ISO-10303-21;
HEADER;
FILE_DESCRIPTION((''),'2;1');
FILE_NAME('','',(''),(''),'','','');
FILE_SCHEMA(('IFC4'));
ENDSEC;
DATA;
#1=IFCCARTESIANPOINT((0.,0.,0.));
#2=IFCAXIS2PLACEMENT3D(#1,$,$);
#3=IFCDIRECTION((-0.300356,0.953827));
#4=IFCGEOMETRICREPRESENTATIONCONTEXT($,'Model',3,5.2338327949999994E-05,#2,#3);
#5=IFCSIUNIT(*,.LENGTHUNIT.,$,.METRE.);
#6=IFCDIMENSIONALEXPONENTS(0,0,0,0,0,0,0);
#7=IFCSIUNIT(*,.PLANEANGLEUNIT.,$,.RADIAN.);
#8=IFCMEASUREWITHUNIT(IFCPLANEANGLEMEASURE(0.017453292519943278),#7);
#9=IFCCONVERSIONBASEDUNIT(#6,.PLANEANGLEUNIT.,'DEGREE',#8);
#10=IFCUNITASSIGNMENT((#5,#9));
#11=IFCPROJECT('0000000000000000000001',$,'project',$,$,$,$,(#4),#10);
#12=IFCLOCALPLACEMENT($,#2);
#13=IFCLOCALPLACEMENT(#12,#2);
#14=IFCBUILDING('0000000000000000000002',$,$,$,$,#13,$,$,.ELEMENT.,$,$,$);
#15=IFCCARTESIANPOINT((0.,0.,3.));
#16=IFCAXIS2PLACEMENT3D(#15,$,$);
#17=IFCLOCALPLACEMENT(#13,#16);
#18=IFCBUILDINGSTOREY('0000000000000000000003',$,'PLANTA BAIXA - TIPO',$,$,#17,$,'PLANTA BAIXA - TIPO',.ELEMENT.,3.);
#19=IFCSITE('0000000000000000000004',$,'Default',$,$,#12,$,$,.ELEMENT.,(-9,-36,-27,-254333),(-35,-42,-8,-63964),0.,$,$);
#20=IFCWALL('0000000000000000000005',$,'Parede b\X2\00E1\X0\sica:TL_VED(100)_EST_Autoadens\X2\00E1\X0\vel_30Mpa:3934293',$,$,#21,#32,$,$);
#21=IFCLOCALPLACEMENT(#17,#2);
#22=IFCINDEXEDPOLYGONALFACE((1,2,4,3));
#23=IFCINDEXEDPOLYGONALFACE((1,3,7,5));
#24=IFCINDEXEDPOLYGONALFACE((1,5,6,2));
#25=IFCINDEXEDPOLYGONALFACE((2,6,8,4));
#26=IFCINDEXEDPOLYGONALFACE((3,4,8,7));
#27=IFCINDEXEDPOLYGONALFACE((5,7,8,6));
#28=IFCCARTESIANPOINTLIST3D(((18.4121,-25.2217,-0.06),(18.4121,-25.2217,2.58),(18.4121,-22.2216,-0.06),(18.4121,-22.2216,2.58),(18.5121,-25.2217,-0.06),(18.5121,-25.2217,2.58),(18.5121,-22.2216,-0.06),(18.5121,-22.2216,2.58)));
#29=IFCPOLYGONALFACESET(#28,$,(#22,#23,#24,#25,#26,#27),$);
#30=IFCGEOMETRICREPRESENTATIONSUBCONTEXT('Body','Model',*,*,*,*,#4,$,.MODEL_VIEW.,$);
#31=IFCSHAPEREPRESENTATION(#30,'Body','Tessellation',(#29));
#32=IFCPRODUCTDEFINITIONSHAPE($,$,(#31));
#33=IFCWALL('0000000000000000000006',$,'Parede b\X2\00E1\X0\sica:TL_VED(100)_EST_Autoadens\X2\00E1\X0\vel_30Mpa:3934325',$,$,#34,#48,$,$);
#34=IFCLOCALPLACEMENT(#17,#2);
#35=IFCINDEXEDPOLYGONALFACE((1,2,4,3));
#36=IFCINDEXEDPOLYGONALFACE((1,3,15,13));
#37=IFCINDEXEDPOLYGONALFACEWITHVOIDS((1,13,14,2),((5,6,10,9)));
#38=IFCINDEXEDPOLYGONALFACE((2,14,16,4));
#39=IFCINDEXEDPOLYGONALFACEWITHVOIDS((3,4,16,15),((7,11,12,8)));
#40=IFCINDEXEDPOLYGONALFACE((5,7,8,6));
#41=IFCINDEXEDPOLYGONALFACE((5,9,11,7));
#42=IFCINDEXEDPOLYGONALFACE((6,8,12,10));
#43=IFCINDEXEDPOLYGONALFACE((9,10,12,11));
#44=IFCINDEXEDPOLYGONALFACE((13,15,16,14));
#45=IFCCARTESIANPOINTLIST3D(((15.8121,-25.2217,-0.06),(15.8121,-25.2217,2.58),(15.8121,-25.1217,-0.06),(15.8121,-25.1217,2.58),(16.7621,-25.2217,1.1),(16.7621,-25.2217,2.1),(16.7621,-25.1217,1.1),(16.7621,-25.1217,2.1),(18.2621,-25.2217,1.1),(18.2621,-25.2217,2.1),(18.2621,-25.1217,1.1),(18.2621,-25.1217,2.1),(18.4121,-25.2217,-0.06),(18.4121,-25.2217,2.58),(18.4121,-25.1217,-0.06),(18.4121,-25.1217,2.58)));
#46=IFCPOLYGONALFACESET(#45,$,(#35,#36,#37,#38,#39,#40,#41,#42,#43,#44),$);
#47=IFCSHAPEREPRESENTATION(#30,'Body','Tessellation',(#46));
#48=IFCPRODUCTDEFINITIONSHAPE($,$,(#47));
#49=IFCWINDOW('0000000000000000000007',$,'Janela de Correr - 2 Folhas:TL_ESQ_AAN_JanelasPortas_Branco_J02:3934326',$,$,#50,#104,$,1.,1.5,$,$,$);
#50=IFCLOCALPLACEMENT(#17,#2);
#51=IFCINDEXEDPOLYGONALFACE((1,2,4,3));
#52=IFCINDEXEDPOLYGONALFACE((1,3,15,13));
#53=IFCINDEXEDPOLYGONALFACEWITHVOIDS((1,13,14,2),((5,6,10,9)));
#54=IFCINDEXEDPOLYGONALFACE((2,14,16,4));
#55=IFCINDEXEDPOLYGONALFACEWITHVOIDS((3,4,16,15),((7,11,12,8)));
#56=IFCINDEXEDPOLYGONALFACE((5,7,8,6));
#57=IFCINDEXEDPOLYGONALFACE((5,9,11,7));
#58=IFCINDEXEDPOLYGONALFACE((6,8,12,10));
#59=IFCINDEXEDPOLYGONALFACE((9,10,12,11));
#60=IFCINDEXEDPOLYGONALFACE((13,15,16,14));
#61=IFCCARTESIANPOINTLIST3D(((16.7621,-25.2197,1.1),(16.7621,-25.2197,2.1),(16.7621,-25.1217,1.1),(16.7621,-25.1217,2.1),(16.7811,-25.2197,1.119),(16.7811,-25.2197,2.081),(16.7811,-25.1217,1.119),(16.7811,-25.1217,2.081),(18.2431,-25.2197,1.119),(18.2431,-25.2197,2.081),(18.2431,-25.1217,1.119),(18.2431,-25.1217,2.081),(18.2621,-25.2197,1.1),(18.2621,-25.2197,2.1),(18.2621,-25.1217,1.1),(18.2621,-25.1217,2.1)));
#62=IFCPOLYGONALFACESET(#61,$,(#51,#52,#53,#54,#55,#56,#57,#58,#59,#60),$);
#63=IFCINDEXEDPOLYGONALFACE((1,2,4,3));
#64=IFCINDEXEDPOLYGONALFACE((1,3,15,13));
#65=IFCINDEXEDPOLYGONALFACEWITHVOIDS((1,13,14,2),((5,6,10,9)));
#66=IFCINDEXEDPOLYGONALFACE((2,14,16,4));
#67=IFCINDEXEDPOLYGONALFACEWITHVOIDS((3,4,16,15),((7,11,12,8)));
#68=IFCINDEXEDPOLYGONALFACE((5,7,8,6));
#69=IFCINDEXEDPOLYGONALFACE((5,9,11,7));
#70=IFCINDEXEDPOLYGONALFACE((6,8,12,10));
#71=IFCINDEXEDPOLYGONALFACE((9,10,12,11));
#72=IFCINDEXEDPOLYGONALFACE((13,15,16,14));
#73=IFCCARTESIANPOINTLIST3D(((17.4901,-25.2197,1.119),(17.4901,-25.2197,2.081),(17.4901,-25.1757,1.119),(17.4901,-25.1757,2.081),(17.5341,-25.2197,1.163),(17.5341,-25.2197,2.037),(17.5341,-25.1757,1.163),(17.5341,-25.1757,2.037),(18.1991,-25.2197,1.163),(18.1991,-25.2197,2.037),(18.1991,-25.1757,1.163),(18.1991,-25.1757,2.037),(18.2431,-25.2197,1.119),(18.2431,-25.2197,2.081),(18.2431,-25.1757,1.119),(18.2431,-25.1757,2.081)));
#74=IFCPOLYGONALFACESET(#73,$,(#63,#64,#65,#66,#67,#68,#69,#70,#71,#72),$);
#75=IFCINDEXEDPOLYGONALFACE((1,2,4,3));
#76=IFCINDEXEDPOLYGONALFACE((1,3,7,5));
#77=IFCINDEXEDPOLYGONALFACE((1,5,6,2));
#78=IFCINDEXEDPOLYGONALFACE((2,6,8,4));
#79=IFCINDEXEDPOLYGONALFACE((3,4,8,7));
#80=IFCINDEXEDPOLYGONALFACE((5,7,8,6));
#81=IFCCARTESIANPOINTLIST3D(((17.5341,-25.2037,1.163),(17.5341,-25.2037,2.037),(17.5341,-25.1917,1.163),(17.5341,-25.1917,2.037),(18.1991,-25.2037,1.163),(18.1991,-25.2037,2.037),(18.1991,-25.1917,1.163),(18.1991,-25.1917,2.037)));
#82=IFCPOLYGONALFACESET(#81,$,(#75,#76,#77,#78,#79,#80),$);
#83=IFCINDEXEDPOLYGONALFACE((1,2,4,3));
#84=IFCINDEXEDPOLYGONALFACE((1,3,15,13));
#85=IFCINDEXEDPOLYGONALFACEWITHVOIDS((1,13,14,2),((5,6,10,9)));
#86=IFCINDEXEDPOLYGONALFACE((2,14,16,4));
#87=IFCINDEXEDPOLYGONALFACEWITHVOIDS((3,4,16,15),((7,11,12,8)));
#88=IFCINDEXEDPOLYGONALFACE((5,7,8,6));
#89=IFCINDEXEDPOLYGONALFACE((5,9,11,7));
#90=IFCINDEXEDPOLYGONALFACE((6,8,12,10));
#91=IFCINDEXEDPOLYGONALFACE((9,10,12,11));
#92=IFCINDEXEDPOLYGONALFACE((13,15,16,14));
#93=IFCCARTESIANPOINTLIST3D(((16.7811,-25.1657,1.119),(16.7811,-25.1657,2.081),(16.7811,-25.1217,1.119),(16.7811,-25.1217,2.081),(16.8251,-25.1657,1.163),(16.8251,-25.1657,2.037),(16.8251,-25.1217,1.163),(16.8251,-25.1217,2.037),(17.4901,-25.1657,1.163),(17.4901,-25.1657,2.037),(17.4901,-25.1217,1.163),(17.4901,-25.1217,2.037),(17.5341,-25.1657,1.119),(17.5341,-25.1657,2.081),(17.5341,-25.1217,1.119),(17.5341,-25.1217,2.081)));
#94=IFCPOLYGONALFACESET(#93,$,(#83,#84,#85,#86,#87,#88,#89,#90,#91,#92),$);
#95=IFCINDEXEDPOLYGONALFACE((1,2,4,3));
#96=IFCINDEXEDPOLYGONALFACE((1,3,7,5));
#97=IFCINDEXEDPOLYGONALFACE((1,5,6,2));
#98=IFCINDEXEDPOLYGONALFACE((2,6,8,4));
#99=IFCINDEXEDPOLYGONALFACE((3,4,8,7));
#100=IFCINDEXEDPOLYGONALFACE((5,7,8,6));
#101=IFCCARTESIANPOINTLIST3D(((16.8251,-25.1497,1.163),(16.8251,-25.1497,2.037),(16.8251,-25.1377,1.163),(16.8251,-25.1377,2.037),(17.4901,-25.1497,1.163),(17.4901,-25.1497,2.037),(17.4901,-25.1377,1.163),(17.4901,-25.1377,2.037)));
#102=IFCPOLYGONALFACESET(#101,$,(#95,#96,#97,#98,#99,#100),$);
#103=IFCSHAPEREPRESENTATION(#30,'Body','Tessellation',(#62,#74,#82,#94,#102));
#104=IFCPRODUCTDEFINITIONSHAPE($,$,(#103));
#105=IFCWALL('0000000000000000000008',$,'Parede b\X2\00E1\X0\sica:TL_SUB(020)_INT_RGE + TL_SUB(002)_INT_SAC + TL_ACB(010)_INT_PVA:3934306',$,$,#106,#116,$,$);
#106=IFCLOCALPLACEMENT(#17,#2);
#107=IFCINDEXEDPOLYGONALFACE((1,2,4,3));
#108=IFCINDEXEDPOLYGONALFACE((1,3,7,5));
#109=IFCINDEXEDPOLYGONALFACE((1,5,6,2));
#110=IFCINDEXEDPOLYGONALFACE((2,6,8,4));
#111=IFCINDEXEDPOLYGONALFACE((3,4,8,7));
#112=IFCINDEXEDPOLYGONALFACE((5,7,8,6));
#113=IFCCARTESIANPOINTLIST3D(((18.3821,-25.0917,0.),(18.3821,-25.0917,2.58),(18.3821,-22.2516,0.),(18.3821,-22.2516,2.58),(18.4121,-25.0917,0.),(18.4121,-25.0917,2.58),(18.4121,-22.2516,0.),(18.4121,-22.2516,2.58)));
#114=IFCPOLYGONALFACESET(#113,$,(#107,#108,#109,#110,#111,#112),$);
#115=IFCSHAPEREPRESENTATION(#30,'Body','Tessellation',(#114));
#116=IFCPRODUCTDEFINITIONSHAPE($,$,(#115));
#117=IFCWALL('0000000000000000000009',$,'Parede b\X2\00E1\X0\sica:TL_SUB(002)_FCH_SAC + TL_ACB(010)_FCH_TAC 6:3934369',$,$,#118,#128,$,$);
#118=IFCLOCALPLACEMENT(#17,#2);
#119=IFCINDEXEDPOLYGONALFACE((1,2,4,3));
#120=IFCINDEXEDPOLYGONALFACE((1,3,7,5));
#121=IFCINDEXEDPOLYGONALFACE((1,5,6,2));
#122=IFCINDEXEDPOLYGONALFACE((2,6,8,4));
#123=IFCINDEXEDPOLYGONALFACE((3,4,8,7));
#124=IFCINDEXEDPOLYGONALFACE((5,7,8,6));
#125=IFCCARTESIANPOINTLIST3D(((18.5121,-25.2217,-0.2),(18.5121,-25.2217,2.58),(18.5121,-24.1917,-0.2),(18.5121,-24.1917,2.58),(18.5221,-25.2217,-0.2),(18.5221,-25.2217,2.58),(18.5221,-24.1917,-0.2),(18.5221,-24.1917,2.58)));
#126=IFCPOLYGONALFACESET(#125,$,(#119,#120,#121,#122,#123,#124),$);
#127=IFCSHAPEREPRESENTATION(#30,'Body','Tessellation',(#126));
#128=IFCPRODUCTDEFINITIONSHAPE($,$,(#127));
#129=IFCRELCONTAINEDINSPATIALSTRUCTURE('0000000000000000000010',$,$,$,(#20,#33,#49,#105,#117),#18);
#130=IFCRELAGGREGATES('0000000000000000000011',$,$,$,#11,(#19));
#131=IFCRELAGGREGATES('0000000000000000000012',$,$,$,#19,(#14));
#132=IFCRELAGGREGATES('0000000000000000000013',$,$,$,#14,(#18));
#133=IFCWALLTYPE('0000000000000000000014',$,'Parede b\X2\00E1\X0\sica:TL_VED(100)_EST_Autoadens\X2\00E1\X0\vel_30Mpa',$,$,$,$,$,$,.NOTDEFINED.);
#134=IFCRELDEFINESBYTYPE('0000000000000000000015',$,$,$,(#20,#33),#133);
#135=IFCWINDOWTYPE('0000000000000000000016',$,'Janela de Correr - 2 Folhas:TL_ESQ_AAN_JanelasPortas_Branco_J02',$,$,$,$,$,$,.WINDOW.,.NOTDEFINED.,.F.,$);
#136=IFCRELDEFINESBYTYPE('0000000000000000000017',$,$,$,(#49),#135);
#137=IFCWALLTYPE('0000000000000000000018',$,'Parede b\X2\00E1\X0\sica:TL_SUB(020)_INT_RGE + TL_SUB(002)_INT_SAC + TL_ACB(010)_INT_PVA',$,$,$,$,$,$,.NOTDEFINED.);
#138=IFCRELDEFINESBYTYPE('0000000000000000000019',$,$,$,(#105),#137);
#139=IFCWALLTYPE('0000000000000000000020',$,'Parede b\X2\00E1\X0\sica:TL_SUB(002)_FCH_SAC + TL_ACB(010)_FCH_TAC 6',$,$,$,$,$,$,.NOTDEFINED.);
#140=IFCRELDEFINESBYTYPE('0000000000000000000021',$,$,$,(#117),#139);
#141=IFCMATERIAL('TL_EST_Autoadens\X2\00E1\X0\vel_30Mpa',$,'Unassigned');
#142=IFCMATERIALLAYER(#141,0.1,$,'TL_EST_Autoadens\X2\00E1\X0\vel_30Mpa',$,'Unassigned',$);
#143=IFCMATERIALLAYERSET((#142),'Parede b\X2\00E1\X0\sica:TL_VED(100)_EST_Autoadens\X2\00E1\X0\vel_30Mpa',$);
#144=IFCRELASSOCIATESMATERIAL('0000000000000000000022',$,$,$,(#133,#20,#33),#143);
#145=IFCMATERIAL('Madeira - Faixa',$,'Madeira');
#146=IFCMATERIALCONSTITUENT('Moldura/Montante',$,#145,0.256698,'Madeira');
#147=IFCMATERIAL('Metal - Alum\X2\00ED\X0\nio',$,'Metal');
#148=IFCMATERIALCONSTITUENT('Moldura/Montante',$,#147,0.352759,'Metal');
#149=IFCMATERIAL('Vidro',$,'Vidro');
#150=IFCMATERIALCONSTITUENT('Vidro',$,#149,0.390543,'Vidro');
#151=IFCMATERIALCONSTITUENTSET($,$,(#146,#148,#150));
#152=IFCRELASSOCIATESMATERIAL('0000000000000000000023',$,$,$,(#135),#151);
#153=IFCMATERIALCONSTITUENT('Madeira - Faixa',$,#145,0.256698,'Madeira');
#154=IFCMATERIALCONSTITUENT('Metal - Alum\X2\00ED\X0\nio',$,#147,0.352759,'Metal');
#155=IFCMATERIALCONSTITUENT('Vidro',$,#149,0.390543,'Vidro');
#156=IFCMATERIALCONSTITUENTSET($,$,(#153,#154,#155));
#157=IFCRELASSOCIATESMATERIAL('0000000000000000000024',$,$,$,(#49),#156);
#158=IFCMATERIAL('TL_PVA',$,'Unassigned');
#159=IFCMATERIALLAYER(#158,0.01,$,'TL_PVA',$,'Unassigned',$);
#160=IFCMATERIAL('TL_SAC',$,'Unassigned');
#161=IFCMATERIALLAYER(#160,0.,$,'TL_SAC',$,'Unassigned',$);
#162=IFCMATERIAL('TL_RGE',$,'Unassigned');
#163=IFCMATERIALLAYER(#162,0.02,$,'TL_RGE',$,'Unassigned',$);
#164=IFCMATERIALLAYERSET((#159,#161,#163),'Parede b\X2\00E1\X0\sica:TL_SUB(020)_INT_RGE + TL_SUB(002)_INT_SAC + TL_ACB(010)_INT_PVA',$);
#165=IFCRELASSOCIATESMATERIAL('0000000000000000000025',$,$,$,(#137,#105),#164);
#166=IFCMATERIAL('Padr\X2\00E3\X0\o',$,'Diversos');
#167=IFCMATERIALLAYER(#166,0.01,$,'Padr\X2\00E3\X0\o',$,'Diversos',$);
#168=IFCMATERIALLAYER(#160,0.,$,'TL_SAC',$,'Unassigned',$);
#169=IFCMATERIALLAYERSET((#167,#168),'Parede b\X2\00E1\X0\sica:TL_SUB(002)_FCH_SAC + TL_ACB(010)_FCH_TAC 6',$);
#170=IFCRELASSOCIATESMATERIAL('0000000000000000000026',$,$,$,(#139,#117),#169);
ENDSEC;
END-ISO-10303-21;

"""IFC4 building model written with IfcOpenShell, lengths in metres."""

from ifc_helpers import new_model, entity, si_unit, converted_unit, direction, frame, frame_2d, origin, origin_2d_with_axis, place, context, subcontext, project, spatial, polyline, rectangle, outline, extrude, source, transform, mapped, material, layer, layer_set, layer_usage, constituent, constituent_set, type_object, type_shapes, element, fill, save


model = new_model("IFC4")

# Units and contexts
model_context = context("Model", 3, precision=5.2338327949999994e-05, world=origin(), true_north=direction((-0.300356, 0.953827)))
body_context = subcontext(model_context, "Body", "Model", "MODEL_VIEW")
ifc_project = project(units=[si_unit("LENGTHUNIT", "METRE"), converted_unit("PLANEANGLEUNIT", "DEGREE", entity("IfcPlaneAngleMeasure", 0.017453292519943278), si_unit("PLANEANGLEUNIT", "RADIAN"), dimensions=[0, 0, 0, 0, 0, 0, 0])], contexts=[model_context])

# Site, building, storey
site_placement = place(None, origin())
site = spatial("IfcSite", under=ifc_project, at=site_placement, Name="Default", CompositionType="ELEMENT", RefLatitude=(-9, -36, -27, -254333), RefLongitude=(-35, -42, -8, -63964), RefElevation=0.0)
building_placement = place(site_placement, origin())
building = spatial("IfcBuilding", under=site, at=building_placement, CompositionType="ELEMENT")
storey_placement = place(building_placement, frame((0.0, 0.0, 3.0)))
storey = spatial("IfcBuildingStorey", under=building, at=storey_placement, Name="PLANTA BAIXA - TIPO", LongName="PLANTA BAIXA - TIPO", CompositionType="ELEMENT", Elevation=3.0)

# Wall
ifc_material_1 = material(Name="TL_EST_Autoadensável_30Mpa", Category="Unassigned")
ifc_layer_1 = layer(ifc_material_1, 0.1, Name="TL_EST_Autoadensável_30Mpa", Category="Unassigned")
ifc_layer_set_1 = layer_set([ifc_layer_1], Name="Parede básica:TL_VED(100)_EST_Autoadensável_30Mpa")
ifc_layer_usage_1 = layer_usage(ifc_layer_set_1, "AXIS2", "NEGATIVE", 0.05)
wall_type_1 = type_object("IfcWallType", Name="Parede básica:TL_VED(100)_EST_Autoadensável_30Mpa", PredefinedType="NOTDEFINED", material=ifc_layer_set_1)
wall_1_placement = place(storey_placement, frame((18.4621, -25.2217, -0.06), z_axis=(0.0, 0.0, 1.0), x_axis=(0.0, 1.0, 0.0)))
element("IfcWall", 1, at=wall_1_placement, inside=storey, type_object=wall_type_1, material=ifc_layer_usage_1, Name="Parede básica:TL_VED(100)_EST_Autoadensável_30Mpa:3934293", context=body_context, shape_type="SweptSolid", body=[
    extrude(rectangle(XDim=3.0001, YDim=0.1, at=frame_2d((1.5001, 0.0), x_axis=(-1.0, 0.0))), origin(), (0.0, 0.0, 1.0), 2.64),
])

# Wall, opening, window
ifc_layer_usage_2 = layer_usage(ifc_layer_set_1, "AXIS2", "NEGATIVE", 0.05)
wall_2_placement = place(storey_placement, frame((18.4121, -25.1717, -0.06), z_axis=(0.0, 0.0, 1.0), x_axis=(-1.0, 0.0, 0.0)))
wall_2 = element("IfcWall", 2, at=wall_2_placement, inside=storey, type_object=wall_type_1, material=ifc_layer_usage_2, Name="Parede básica:TL_VED(100)_EST_Autoadensável_30Mpa:3934325", context=body_context, shape_type="SweptSolid", body=[
    extrude(rectangle(XDim=2.6, YDim=0.1, at=frame_2d((1.3, 0.0), x_axis=(-1.0, 0.0))), origin(), (0.0, 0.0, 1.0), 2.64),
])
opening_placement = place(wall_2_placement, frame((0.15, -0.05, 1.16)))
opening = element("IfcOpeningElement", 3, at=opening_placement, cuts=wall_2, PredefinedType="OPENING", context=body_context, shape_type="SweptSolid", body=[
    extrude(rectangle(XDim=1.0, YDim=1.5, at=frame_2d((0.5, 0.75), x_axis=(-1.0, 0.0))), frame((0.0, 0.0, 0.0), z_axis=(0.0, 1.0, 0.0), x_axis=(0.0, 0.0, 1.0)), (0.0, 0.0, 1.0), 0.1),
])
ifc_material_2 = material(Name="Madeira - Faixa", Category="Madeira")
ifc_constituent_1 = constituent(ifc_material_2, Name="Madeira - Faixa", Category="Madeira", fraction=0.256698)
ifc_material_3 = material(Name="Metal - Alumínio", Category="Metal")
ifc_constituent_2 = constituent(ifc_material_3, Name="Metal - Alumínio", Category="Metal", fraction=0.352759)
ifc_material_4 = material(Name="Vidro", Category="Vidro")
ifc_constituent_3 = constituent(ifc_material_4, Name="Vidro", Category="Vidro", fraction=0.390543)
ifc_constituent_set_1 = constituent_set(constituents=[ifc_constituent_1, ifc_constituent_2, ifc_constituent_3])
ifc_constituent_4 = constituent(ifc_material_2, Name="Moldura/Montante", Category="Madeira", fraction=0.256698)
ifc_constituent_5 = constituent(ifc_material_3, Name="Moldura/Montante", Category="Metal", fraction=0.352759)
ifc_constituent_6 = constituent(ifc_material_4, Name="Vidro", Category="Vidro", fraction=0.390543)
ifc_constituent_set_2 = constituent_set(constituents=[ifc_constituent_4, ifc_constituent_5, ifc_constituent_6])
window_type = type_object("IfcWindowType", Name="Janela de Correr - 2 Folhas:TL_ESQ_AAN_JanelasPortas_Branco_J02", ParameterTakesPrecedence=False, PartitioningType="NOTDEFINED", PredefinedType="WINDOW", material=ifc_constituent_set_2)
shared_shape_1 = source(origin(), body_context, "Body", "SweptSolid", [
    extrude(outline(polyline([(-0.75, -0.5), (0.75, -0.5), (0.75, 0.5), (-0.75, 0.5), (-0.75, -0.5)]), holes=[polyline([(-0.731, -0.481), (-0.731, 0.481), (0.731, 0.481), (0.731, -0.481), (-0.731, -0.481)])]), frame((0.75, 0.124, 0.5), z_axis=(0.0, -1.0, 0.0), x_axis=(-1.0, 0.0, 0.0)), (0.0, 0.0, 1.0), 0.098),
    extrude(outline(polyline([(-0.3765, -0.481), (0.3765, -0.481), (0.3765, 0.481), (-0.3765, 0.481), (-0.3765, -0.481)]), holes=[polyline([(-0.3325, -0.437), (-0.3325, 0.437), (0.3325, 0.437), (0.3325, -0.437), (-0.3325, -0.437)])]), frame((0.3955, 0.124, 0.5), z_axis=(0.0, -1.0, 0.0), x_axis=(-1.0, 0.0, 0.0)), (0.0, 0.0, 1.0), 0.044),
    extrude(rectangle(XDim=0.665, YDim=0.012, at=origin_2d_with_axis()), frame((0.3955, 0.102, 0.063), z_axis=(0.0, 0.0, 1.0), x_axis=(-1.0, 0.0, 0.0)), (0.0, 0.0, 1.0), 0.874),
    extrude(outline(polyline([(-0.481, -0.3765), (0.481, -0.3765), (0.481, 0.3765), (-0.481, 0.3765), (-0.481, -0.3765)]), holes=[polyline([(-0.437, -0.3325), (-0.437, 0.3325), (0.437, 0.3325), (0.437, -0.3325), (-0.437, -0.3325)])]), frame((1.1045, 0.07, 0.5), z_axis=(0.0, -1.0, 0.0), x_axis=(0.0, 0.0, -1.0)), (0.0, 0.0, 1.0), 0.044),
    extrude(rectangle(XDim=0.665, YDim=0.012, at=origin_2d_with_axis()), frame((1.1045, 0.048, 0.063), z_axis=(0.0, 0.0, 1.0), x_axis=(-1.0, 0.0, 0.0)), (0.0, 0.0, 1.0), 0.874),
])
type_shapes(window_type, [shared_shape_1])
window_placement = place(opening_placement, frame((0.0, -0.026, 0.0)))
window = element("IfcWindow", 4, at=window_placement, inside=storey, type_object=window_type, material=ifc_constituent_set_1, Name="Janela de Correr - 2 Folhas:TL_ESQ_AAN_JanelasPortas_Branco_J02:3934326", OverallHeight=1.0, OverallWidth=1.5, context=body_context, shape_type="MappedRepresentation", body=[
    mapped(shared_shape_1, transform((0.0, 0.0, 0.0), scale=1.0)),
])
fill(opening, window)

# Walls
ifc_material_5 = material(Name="TL_PVA", Category="Unassigned")
ifc_layer_2 = layer(ifc_material_5, 0.01, Name="TL_PVA", Category="Unassigned")
ifc_material_6 = material(Name="TL_SAC", Category="Unassigned")
ifc_layer_3 = layer(ifc_material_6, 0.0, Name="TL_SAC", Category="Unassigned")
ifc_material_7 = material(Name="TL_RGE", Category="Unassigned")
ifc_layer_4 = layer(ifc_material_7, 0.02, Name="TL_RGE", Category="Unassigned")
ifc_layer_set_2 = layer_set([ifc_layer_2, ifc_layer_3, ifc_layer_4], Name="Parede básica:TL_SUB(020)_INT_RGE + TL_SUB(002)_INT_SAC + TL_ACB(010)_INT_PVA")
ifc_layer_usage_3 = layer_usage(ifc_layer_set_2, "AXIS2", "NEGATIVE", 0.015)
wall_type_2 = type_object("IfcWallType", Name="Parede básica:TL_SUB(020)_INT_RGE + TL_SUB(002)_INT_SAC + TL_ACB(010)_INT_PVA", PredefinedType="NOTDEFINED", material=ifc_layer_set_2)
wall_3_placement = place(storey_placement, frame((18.3971, -25.0917, 0.0), z_axis=(0.0, 0.0, 1.0), x_axis=(0.0, 1.0, 0.0)))
element("IfcWall", 5, at=wall_3_placement, inside=storey, type_object=wall_type_2, material=ifc_layer_usage_3, Name="Parede básica:TL_SUB(020)_INT_RGE + TL_SUB(002)_INT_SAC + TL_ACB(010)_INT_PVA:3934306", context=body_context, shape_type="SweptSolid", body=[
    extrude(rectangle(XDim=2.8401, YDim=0.03, at=frame_2d((1.4201, 0.0), x_axis=(-1.0, 0.0))), origin(), (0.0, 0.0, 1.0), 2.58),
])
ifc_material_8 = material(Name="Padrão", Category="Diversos")
ifc_layer_5 = layer(ifc_material_8, 0.01, Name="Padrão", Category="Diversos")
ifc_layer_6 = layer(ifc_material_6, 0.0, Name="TL_SAC", Category="Unassigned")
ifc_layer_set_3 = layer_set([ifc_layer_5, ifc_layer_6], Name="Parede básica:TL_SUB(002)_FCH_SAC + TL_ACB(010)_FCH_TAC 6")
ifc_layer_usage_4 = layer_usage(ifc_layer_set_3, "AXIS2", "NEGATIVE", 0.005)
wall_type_3 = type_object("IfcWallType", Name="Parede básica:TL_SUB(002)_FCH_SAC + TL_ACB(010)_FCH_TAC 6", PredefinedType="NOTDEFINED", material=ifc_layer_set_3)
wall_4_placement = place(storey_placement, frame((18.5171, -25.2217, -0.2), z_axis=(0.0, 0.0, 1.0), x_axis=(0.0, 1.0, 0.0)))
element("IfcWall", 6, at=wall_4_placement, inside=storey, type_object=wall_type_3, material=ifc_layer_usage_4, Name="Parede básica:TL_SUB(002)_FCH_SAC + TL_ACB(010)_FCH_TAC 6:3934369", context=body_context, shape_type="SweptSolid", body=[
    extrude(rectangle(XDim=1.03, YDim=0.01, at=frame_2d((0.515, 0.0), x_axis=(-1.0, 0.0))), origin(), (0.0, 0.0, 1.0), 2.78),
])

save(model, "model.ifc")
